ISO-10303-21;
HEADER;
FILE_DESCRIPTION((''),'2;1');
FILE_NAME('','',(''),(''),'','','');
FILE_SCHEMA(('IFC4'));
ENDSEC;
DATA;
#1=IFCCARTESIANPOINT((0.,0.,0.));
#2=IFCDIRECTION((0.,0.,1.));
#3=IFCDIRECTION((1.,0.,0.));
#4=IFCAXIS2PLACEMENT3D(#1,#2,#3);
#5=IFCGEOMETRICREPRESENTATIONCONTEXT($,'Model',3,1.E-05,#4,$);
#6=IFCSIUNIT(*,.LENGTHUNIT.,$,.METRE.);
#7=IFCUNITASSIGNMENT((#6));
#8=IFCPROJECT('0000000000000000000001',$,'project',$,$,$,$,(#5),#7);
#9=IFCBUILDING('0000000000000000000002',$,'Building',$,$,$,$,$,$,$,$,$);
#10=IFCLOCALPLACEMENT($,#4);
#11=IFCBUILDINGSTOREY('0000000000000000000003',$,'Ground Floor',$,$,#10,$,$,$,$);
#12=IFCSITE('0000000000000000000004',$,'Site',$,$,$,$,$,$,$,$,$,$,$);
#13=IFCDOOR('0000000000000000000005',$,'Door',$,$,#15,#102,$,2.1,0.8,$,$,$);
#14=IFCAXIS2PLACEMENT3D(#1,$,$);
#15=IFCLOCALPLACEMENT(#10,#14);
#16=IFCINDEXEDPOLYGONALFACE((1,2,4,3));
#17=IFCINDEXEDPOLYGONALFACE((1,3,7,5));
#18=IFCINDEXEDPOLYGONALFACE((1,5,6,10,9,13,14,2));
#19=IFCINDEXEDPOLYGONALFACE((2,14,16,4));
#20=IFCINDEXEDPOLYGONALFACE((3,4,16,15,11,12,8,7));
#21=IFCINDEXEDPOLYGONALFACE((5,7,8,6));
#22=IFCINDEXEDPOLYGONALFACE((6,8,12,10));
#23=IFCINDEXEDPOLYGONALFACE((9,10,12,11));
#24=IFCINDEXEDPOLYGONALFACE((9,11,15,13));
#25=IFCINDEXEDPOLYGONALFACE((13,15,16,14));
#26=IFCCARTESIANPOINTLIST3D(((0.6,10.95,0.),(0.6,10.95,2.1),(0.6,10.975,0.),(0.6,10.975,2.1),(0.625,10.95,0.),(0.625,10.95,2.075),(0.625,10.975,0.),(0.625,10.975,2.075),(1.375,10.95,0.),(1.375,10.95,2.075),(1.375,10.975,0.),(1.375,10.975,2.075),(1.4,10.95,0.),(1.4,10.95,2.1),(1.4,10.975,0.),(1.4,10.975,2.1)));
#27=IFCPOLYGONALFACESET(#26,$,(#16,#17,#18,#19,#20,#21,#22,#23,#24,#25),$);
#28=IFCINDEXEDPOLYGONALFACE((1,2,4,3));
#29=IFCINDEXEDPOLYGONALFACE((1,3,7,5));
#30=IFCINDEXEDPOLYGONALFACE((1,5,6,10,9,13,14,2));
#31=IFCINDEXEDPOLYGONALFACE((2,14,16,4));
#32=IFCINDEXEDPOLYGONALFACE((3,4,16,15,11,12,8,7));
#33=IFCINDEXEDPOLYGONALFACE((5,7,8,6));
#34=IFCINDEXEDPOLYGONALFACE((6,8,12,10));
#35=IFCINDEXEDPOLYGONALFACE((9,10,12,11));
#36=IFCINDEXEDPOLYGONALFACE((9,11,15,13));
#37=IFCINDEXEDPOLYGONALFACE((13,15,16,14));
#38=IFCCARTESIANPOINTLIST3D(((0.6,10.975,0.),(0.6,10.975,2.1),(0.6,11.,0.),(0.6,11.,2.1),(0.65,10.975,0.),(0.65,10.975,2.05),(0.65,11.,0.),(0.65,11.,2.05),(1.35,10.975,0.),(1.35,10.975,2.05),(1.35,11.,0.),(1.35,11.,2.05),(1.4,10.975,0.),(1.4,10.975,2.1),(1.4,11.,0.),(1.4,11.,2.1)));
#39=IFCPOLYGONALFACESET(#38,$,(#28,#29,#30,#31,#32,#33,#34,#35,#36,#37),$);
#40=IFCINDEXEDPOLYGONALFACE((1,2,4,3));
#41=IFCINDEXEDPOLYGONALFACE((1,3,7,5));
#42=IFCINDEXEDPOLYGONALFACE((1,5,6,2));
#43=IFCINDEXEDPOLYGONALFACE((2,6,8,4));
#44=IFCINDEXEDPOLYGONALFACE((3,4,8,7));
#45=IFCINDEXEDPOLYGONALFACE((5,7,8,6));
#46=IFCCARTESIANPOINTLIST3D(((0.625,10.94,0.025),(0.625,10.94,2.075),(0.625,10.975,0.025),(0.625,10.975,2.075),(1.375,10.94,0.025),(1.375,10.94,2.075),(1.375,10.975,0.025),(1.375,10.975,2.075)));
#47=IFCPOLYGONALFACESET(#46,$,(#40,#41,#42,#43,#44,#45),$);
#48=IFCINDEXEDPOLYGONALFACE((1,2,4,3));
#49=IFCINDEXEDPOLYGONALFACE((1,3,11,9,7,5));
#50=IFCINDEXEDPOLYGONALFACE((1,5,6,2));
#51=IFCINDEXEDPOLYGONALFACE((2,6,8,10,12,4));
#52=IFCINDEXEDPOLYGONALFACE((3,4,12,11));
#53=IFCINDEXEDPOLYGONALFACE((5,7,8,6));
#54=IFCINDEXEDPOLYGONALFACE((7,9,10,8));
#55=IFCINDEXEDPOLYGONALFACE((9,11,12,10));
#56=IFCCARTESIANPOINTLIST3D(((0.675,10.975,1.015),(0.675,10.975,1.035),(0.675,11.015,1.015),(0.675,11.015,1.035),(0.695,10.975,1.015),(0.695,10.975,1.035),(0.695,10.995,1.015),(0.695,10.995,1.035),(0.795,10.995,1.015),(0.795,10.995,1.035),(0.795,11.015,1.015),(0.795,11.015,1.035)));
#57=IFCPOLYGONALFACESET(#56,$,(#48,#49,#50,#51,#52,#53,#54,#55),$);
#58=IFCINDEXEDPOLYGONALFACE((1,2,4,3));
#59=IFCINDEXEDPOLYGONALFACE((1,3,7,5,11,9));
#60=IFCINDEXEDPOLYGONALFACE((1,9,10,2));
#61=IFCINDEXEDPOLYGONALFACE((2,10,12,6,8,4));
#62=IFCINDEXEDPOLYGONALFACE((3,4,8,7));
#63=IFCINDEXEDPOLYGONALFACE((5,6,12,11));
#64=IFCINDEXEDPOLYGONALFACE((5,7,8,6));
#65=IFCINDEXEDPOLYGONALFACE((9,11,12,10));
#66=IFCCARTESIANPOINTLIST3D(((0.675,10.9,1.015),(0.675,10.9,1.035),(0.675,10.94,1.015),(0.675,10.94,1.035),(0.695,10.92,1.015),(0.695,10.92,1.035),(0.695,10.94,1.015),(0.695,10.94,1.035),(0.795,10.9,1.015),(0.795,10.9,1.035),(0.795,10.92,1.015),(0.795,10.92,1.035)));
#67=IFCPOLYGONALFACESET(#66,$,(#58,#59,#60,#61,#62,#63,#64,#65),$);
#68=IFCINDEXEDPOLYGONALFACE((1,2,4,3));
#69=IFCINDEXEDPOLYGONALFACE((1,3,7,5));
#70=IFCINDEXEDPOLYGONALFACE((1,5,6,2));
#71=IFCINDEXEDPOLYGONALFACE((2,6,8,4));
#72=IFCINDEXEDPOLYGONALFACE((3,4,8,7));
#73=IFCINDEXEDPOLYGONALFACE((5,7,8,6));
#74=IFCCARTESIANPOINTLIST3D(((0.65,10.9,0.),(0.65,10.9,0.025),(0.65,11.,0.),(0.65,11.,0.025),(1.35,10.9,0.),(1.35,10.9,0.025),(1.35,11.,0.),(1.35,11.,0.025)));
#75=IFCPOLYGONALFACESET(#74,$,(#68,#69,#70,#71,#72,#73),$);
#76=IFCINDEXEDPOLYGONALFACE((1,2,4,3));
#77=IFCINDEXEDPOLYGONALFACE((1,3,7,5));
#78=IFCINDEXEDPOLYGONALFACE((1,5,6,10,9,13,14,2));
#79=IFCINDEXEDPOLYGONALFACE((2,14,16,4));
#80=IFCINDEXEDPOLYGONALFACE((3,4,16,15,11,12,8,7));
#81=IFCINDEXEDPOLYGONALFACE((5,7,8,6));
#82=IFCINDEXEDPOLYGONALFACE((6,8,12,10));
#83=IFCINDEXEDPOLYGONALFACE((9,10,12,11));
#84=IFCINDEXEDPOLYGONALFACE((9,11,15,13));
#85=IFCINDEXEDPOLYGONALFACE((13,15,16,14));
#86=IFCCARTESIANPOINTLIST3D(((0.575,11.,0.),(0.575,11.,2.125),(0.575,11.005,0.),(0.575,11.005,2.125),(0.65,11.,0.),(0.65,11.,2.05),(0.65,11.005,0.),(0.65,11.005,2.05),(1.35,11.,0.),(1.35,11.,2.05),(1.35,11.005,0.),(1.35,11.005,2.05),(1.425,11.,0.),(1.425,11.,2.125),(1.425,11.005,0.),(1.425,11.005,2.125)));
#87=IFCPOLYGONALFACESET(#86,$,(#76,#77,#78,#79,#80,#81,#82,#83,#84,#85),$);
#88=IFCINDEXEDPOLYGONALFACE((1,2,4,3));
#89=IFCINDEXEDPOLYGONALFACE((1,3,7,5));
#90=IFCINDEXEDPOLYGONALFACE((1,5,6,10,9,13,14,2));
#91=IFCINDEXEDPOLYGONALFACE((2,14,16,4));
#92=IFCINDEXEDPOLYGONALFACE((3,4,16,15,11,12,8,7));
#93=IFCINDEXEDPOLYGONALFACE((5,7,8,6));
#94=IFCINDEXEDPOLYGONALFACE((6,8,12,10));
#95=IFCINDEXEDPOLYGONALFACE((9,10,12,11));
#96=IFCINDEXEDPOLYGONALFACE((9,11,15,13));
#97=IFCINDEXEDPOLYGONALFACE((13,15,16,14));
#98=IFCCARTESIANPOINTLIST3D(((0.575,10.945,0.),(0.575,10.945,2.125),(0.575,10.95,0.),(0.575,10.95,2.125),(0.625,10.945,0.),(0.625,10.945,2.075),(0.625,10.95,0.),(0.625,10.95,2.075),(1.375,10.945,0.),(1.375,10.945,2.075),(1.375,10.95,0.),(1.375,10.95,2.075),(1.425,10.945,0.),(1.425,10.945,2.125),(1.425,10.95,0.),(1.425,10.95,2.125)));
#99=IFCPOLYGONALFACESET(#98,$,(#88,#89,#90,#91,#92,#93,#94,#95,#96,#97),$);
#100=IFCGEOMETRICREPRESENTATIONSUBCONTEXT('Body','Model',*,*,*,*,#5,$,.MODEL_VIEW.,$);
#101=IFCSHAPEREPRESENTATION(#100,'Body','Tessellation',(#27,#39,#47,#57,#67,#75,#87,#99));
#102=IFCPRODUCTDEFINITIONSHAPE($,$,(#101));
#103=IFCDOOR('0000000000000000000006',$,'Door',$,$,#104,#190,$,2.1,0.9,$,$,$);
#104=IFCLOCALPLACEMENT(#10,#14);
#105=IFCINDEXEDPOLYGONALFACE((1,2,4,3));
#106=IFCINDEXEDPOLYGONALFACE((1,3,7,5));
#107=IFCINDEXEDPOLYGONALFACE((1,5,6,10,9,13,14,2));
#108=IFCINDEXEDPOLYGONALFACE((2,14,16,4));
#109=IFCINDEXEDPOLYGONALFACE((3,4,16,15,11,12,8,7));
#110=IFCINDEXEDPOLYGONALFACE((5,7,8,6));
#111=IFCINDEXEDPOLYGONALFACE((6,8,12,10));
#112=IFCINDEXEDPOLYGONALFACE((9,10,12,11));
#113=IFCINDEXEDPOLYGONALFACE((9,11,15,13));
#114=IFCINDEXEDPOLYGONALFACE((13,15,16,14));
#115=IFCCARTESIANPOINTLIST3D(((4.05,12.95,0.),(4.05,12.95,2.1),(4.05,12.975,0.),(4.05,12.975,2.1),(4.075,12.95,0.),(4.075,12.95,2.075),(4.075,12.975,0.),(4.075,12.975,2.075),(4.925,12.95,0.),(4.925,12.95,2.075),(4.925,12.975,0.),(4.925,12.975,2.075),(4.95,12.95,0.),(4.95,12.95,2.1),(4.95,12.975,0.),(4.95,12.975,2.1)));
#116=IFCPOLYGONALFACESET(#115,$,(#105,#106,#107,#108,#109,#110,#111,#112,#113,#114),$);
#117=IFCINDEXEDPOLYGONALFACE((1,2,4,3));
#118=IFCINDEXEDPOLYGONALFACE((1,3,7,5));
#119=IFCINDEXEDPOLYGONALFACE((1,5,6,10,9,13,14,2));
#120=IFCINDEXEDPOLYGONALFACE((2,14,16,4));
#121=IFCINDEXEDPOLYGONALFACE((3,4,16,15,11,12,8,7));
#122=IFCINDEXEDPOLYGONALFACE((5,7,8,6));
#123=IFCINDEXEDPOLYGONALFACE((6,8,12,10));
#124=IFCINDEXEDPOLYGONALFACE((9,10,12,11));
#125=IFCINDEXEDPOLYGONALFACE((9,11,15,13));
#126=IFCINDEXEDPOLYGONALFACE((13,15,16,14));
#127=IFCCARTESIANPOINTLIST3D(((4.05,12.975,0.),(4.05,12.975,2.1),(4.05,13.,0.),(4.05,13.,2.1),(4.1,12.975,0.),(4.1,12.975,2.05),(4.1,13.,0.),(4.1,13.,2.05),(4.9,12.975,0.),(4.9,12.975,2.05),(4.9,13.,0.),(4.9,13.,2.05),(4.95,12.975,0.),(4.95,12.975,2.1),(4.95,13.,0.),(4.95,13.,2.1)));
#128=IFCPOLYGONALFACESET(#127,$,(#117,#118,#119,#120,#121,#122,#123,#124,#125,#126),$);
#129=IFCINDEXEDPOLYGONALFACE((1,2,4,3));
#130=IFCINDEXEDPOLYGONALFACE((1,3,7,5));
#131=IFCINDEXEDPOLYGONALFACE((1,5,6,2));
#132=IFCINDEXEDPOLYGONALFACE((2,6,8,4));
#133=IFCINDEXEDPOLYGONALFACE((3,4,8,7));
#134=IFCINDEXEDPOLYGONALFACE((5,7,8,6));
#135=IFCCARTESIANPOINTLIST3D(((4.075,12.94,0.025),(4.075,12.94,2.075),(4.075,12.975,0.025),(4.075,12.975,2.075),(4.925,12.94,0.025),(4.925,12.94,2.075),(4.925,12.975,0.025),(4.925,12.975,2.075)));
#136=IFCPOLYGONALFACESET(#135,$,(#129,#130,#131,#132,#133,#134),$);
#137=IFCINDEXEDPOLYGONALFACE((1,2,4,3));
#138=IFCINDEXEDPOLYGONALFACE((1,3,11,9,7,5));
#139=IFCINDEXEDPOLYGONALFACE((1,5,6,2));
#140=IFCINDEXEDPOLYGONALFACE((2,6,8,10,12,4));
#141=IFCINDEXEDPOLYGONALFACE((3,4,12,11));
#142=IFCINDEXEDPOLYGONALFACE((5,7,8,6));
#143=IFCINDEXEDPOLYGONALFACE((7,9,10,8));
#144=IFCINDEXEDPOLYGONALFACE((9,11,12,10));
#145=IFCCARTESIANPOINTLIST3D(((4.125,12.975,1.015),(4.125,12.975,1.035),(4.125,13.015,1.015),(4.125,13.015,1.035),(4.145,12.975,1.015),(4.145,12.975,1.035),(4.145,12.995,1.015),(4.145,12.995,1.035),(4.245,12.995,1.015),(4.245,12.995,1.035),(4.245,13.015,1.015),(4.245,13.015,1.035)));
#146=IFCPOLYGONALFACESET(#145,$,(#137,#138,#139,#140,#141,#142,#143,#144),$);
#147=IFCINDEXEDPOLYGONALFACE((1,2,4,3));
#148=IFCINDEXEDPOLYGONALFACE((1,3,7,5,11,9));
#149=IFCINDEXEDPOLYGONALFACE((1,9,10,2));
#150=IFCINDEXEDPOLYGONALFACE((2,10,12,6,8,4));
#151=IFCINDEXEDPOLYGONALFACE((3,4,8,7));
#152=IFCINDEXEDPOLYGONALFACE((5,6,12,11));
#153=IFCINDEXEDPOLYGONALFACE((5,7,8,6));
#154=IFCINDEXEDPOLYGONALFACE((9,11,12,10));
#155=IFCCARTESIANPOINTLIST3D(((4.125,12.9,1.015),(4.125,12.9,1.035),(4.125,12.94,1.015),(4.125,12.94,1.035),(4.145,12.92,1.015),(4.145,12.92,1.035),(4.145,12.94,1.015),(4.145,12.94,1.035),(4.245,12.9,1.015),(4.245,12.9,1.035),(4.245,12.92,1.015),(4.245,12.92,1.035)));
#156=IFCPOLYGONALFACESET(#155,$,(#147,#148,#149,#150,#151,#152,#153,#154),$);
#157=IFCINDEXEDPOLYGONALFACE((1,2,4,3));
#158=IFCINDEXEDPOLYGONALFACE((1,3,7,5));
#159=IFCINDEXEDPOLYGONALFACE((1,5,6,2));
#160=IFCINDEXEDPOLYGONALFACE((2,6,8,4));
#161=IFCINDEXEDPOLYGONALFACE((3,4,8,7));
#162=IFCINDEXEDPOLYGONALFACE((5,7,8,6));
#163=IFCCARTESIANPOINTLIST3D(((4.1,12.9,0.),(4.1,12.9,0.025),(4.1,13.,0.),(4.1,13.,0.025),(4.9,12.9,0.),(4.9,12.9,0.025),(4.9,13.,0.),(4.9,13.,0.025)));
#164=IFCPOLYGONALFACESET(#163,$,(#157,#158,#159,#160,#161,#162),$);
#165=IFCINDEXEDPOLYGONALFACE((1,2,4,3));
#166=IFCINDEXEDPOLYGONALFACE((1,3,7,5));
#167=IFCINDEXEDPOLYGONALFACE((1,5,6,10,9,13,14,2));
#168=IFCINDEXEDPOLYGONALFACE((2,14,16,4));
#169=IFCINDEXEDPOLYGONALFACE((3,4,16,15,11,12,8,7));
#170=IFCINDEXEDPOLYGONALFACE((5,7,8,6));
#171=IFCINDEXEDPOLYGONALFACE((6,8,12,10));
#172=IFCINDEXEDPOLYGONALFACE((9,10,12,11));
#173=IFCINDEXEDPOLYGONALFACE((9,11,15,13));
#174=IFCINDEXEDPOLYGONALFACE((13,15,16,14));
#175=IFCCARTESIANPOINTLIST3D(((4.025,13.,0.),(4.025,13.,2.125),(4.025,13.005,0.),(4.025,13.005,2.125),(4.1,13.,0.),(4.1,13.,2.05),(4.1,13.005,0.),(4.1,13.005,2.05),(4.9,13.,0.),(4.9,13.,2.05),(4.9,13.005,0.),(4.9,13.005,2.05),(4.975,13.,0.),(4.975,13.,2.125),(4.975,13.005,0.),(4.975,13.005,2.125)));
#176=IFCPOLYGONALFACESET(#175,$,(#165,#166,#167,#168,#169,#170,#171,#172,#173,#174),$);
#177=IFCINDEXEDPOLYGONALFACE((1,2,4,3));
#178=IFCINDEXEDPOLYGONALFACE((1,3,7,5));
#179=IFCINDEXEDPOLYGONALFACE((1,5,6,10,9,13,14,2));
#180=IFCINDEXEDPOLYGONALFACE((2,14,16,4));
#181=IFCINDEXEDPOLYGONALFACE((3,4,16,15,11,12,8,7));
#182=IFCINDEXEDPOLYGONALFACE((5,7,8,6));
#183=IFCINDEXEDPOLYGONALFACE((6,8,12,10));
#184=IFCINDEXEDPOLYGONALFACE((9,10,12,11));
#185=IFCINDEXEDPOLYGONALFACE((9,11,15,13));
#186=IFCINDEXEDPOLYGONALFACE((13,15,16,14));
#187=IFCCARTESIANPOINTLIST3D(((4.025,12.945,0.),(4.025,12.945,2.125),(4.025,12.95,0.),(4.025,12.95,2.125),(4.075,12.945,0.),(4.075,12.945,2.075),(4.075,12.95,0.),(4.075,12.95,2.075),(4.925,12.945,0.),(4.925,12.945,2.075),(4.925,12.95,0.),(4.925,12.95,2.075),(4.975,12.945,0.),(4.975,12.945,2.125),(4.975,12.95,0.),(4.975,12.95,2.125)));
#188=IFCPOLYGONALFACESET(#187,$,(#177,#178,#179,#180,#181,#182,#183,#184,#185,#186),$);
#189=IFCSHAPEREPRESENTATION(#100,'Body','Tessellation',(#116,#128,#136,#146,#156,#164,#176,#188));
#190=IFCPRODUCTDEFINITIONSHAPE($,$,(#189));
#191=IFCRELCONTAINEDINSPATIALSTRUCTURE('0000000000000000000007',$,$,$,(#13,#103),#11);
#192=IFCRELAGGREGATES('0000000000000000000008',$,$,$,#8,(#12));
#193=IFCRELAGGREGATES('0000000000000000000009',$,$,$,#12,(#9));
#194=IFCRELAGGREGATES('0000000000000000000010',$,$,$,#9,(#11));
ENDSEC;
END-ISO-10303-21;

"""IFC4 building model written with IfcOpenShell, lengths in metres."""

from ifc_helpers import new_model, si_unit, frame, origin_with_axes, place, context, subcontext, project, spatial, line, indexed_curve, outline, extrude, element, save


model = new_model("IFC4")

# Units and contexts
model_context = context("Model", 3, precision=1e-05, world=origin_with_axes())
body_context = subcontext(model_context, "Body", "Model", "MODEL_VIEW")
ifc_project = project(units=[si_unit("LENGTHUNIT", "METRE")], contexts=[model_context])

# Site, building, storey
site = spatial("IfcSite", under=ifc_project, Name="Site")
building = spatial("IfcBuilding", under=site, Name="Building")
storey_placement = place(None, origin_with_axes())
storey = spatial("IfcBuildingStorey", under=building, at=storey_placement, Name="Ground Floor")

# Doors
door_1_placement = place(storey_placement, frame((1.4, 11.0, 0.0), z_axis=(0.0, 0.0, 1.0), x_axis=(-1.0, 0.0, 0.0)))
element("IfcDoor", 1, at=door_1_placement, inside=storey, Name="Door", OverallHeight=2.1, OverallWidth=0.8, context=body_context, shape_type="SweptSolid", body=[
    extrude(outline(indexed_curve([(0.0, 0.0), (0.0, 2.1), (0.8, 2.1), (0.8, 0.0), (0.775, 0.0), (0.775, 2.075), (0.025, 2.075), (0.025, 0.0)], segments=[line(1, 2, 3, 4, 5, 6, 7, 8, 1)])), frame((0.0, 0.025, 0.0), z_axis=(0.0, -1.0, 0.0), x_axis=(1.0, 0.0, 0.0)), (0.0, 0.0, -1.0), 0.025),
    extrude(outline(indexed_curve([(0.0, 0.0), (0.0, 2.1), (0.8, 2.1), (0.8, 0.0), (0.75, 0.0), (0.75, 2.05), (0.05, 2.05), (0.05, 0.0)], segments=[line(1, 2, 3, 4, 5, 6, 7, 8, 1)])), frame((0.0, 0.0, 0.0), z_axis=(0.0, -1.0, 0.0), x_axis=(1.0, 0.0, 0.0)), (0.0, 0.0, -1.0), 0.025),
    extrude(outline(indexed_curve([(0.0, 0.0), (0.75, 0.0), (0.75, 0.035), (0.0, 0.035)], segments=[line(1, 2, 3, 4, 1)])), frame((0.025, 0.025, 0.025), z_axis=(0.0, 0.0, 1.0), x_axis=(1.0, 0.0, 0.0)), (0.0, 0.0, 1.0), 2.05),
    extrude(outline(indexed_curve([(0.0, 0.0), (0.0, -0.04), (-0.12, -0.04), (-0.12, -0.02), (-0.02, -0.02), (-0.02, 0.0)], segments=[line(1, 2, 3, 4, 5, 6, 1)])), frame((0.725, 0.025, 1.015), z_axis=(0.0, 0.0, 1.0), x_axis=(1.0, 0.0, 0.0)), (0.0, 0.0, 1.0), 0.02),
    extrude(outline(indexed_curve([(0.0, 0.0), (0.0, 0.04), (-0.12, 0.04), (-0.12, 0.02), (-0.02, 0.02), (-0.02, 0.0)], segments=[line(1, 2, 3, 4, 5, 6, 1)])), frame((0.725, 0.06, 1.015), z_axis=(0.0, 0.0, 1.0), x_axis=(1.0, 0.0, 0.0)), (0.0, 0.0, 1.0), 0.02),
    extrude(outline(indexed_curve([(0.0, 0.0), (0.7, 0.0), (0.7, 0.1), (0.0, 0.1)], segments=[line(1, 2, 3, 4, 1)])), frame((0.05, 0.0, 0.0), z_axis=(0.0, 0.0, 1.0), x_axis=(1.0, 0.0, 0.0)), (0.0, 0.0, 1.0), 0.025),
    extrude(outline(indexed_curve([(0.0, 0.0), (0.0, 2.125), (0.85, 2.125), (0.85, 0.0), (0.775, 0.0), (0.775, 2.05), (0.075, 2.05), (0.075, 0.0)], segments=[line(1, 2, 3, 4, 5, 6, 7, 8, 1)])), frame((-0.025, -0.005, 0.0), z_axis=(0.0, -1.0, 0.0), x_axis=(1.0, 0.0, 0.0)), (0.0, 0.0, -1.0), 0.005),
    extrude(outline(indexed_curve([(0.0, 0.0), (0.0, 2.125), (0.85, 2.125), (0.85, 0.0), (0.8, 0.0), (0.8, 2.075), (0.05, 2.075), (0.05, 0.0)], segments=[line(1, 2, 3, 4, 5, 6, 7, 8, 1)])), frame((-0.025, 0.05, 0.0), z_axis=(0.0, -1.0, 0.0), x_axis=(1.0, 0.0, 0.0)), (0.0, 0.0, -1.0), 0.005),
])
door_2_placement = place(storey_placement, frame((4.95, 13.0, 0.0), z_axis=(0.0, 0.0, 1.0), x_axis=(-1.0, 0.0, 0.0)))
element("IfcDoor", 2, at=door_2_placement, inside=storey, Name="Door", OverallHeight=2.1, OverallWidth=0.9, context=body_context, shape_type="SweptSolid", body=[
    extrude(outline(indexed_curve([(0.0, 0.0), (0.0, 2.1), (0.9, 2.1), (0.9, 0.0), (0.875, 0.0), (0.875, 2.075), (0.025, 2.075), (0.025, 0.0)], segments=[line(1, 2, 3, 4, 5, 6, 7, 8, 1)])), frame((0.0, 0.025, 0.0), z_axis=(0.0, -1.0, 0.0), x_axis=(1.0, 0.0, 0.0)), (0.0, 0.0, -1.0), 0.025),
    extrude(outline(indexed_curve([(0.0, 0.0), (0.0, 2.1), (0.9, 2.1), (0.9, 0.0), (0.85, 0.0), (0.85, 2.05), (0.05, 2.05), (0.05, 0.0)], segments=[line(1, 2, 3, 4, 5, 6, 7, 8, 1)])), frame((0.0, 0.0, 0.0), z_axis=(0.0, -1.0, 0.0), x_axis=(1.0, 0.0, 0.0)), (0.0, 0.0, -1.0), 0.025),
    extrude(outline(indexed_curve([(0.0, 0.0), (0.85, 0.0), (0.85, 0.035), (0.0, 0.035)], segments=[line(1, 2, 3, 4, 1)])), frame((0.025, 0.025, 0.025), z_axis=(0.0, 0.0, 1.0), x_axis=(1.0, 0.0, 0.0)), (0.0, 0.0, 1.0), 2.05),
    extrude(outline(indexed_curve([(0.0, 0.0), (0.0, -0.04), (-0.12, -0.04), (-0.12, -0.02), (-0.02, -0.02), (-0.02, 0.0)], segments=[line(1, 2, 3, 4, 5, 6, 1)])), frame((0.825, 0.025, 1.015), z_axis=(0.0, 0.0, 1.0), x_axis=(1.0, 0.0, 0.0)), (0.0, 0.0, 1.0), 0.02),
    extrude(outline(indexed_curve([(0.0, 0.0), (0.0, 0.04), (-0.12, 0.04), (-0.12, 0.02), (-0.02, 0.02), (-0.02, 0.0)], segments=[line(1, 2, 3, 4, 5, 6, 1)])), frame((0.825, 0.06, 1.015), z_axis=(0.0, 0.0, 1.0), x_axis=(1.0, 0.0, 0.0)), (0.0, 0.0, 1.0), 0.02),
    extrude(outline(indexed_curve([(0.0, 0.0), (0.8, 0.0), (0.8, 0.1), (0.0, 0.1)], segments=[line(1, 2, 3, 4, 1)])), frame((0.05, 0.0, 0.0), z_axis=(0.0, 0.0, 1.0), x_axis=(1.0, 0.0, 0.0)), (0.0, 0.0, 1.0), 0.025),
    extrude(outline(indexed_curve([(0.0, 0.0), (0.0, 2.125), (0.95, 2.125), (0.95, 0.0), (0.875, 0.0), (0.875, 2.05), (0.075, 2.05), (0.075, 0.0)], segments=[line(1, 2, 3, 4, 5, 6, 7, 8, 1)])), frame((-0.025, -0.005, 0.0), z_axis=(0.0, -1.0, 0.0), x_axis=(1.0, 0.0, 0.0)), (0.0, 0.0, -1.0), 0.005),
    extrude(outline(indexed_curve([(0.0, 0.0), (0.0, 2.125), (0.95, 2.125), (0.95, 0.0), (0.9, 0.0), (0.9, 2.075), (0.05, 2.075), (0.05, 0.0)], segments=[line(1, 2, 3, 4, 5, 6, 7, 8, 1)])), frame((-0.025, 0.05, 0.0), z_axis=(0.0, -1.0, 0.0), x_axis=(1.0, 0.0, 0.0)), (0.0, 0.0, -1.0), 0.005),
])

save(model, "model.ifc")
